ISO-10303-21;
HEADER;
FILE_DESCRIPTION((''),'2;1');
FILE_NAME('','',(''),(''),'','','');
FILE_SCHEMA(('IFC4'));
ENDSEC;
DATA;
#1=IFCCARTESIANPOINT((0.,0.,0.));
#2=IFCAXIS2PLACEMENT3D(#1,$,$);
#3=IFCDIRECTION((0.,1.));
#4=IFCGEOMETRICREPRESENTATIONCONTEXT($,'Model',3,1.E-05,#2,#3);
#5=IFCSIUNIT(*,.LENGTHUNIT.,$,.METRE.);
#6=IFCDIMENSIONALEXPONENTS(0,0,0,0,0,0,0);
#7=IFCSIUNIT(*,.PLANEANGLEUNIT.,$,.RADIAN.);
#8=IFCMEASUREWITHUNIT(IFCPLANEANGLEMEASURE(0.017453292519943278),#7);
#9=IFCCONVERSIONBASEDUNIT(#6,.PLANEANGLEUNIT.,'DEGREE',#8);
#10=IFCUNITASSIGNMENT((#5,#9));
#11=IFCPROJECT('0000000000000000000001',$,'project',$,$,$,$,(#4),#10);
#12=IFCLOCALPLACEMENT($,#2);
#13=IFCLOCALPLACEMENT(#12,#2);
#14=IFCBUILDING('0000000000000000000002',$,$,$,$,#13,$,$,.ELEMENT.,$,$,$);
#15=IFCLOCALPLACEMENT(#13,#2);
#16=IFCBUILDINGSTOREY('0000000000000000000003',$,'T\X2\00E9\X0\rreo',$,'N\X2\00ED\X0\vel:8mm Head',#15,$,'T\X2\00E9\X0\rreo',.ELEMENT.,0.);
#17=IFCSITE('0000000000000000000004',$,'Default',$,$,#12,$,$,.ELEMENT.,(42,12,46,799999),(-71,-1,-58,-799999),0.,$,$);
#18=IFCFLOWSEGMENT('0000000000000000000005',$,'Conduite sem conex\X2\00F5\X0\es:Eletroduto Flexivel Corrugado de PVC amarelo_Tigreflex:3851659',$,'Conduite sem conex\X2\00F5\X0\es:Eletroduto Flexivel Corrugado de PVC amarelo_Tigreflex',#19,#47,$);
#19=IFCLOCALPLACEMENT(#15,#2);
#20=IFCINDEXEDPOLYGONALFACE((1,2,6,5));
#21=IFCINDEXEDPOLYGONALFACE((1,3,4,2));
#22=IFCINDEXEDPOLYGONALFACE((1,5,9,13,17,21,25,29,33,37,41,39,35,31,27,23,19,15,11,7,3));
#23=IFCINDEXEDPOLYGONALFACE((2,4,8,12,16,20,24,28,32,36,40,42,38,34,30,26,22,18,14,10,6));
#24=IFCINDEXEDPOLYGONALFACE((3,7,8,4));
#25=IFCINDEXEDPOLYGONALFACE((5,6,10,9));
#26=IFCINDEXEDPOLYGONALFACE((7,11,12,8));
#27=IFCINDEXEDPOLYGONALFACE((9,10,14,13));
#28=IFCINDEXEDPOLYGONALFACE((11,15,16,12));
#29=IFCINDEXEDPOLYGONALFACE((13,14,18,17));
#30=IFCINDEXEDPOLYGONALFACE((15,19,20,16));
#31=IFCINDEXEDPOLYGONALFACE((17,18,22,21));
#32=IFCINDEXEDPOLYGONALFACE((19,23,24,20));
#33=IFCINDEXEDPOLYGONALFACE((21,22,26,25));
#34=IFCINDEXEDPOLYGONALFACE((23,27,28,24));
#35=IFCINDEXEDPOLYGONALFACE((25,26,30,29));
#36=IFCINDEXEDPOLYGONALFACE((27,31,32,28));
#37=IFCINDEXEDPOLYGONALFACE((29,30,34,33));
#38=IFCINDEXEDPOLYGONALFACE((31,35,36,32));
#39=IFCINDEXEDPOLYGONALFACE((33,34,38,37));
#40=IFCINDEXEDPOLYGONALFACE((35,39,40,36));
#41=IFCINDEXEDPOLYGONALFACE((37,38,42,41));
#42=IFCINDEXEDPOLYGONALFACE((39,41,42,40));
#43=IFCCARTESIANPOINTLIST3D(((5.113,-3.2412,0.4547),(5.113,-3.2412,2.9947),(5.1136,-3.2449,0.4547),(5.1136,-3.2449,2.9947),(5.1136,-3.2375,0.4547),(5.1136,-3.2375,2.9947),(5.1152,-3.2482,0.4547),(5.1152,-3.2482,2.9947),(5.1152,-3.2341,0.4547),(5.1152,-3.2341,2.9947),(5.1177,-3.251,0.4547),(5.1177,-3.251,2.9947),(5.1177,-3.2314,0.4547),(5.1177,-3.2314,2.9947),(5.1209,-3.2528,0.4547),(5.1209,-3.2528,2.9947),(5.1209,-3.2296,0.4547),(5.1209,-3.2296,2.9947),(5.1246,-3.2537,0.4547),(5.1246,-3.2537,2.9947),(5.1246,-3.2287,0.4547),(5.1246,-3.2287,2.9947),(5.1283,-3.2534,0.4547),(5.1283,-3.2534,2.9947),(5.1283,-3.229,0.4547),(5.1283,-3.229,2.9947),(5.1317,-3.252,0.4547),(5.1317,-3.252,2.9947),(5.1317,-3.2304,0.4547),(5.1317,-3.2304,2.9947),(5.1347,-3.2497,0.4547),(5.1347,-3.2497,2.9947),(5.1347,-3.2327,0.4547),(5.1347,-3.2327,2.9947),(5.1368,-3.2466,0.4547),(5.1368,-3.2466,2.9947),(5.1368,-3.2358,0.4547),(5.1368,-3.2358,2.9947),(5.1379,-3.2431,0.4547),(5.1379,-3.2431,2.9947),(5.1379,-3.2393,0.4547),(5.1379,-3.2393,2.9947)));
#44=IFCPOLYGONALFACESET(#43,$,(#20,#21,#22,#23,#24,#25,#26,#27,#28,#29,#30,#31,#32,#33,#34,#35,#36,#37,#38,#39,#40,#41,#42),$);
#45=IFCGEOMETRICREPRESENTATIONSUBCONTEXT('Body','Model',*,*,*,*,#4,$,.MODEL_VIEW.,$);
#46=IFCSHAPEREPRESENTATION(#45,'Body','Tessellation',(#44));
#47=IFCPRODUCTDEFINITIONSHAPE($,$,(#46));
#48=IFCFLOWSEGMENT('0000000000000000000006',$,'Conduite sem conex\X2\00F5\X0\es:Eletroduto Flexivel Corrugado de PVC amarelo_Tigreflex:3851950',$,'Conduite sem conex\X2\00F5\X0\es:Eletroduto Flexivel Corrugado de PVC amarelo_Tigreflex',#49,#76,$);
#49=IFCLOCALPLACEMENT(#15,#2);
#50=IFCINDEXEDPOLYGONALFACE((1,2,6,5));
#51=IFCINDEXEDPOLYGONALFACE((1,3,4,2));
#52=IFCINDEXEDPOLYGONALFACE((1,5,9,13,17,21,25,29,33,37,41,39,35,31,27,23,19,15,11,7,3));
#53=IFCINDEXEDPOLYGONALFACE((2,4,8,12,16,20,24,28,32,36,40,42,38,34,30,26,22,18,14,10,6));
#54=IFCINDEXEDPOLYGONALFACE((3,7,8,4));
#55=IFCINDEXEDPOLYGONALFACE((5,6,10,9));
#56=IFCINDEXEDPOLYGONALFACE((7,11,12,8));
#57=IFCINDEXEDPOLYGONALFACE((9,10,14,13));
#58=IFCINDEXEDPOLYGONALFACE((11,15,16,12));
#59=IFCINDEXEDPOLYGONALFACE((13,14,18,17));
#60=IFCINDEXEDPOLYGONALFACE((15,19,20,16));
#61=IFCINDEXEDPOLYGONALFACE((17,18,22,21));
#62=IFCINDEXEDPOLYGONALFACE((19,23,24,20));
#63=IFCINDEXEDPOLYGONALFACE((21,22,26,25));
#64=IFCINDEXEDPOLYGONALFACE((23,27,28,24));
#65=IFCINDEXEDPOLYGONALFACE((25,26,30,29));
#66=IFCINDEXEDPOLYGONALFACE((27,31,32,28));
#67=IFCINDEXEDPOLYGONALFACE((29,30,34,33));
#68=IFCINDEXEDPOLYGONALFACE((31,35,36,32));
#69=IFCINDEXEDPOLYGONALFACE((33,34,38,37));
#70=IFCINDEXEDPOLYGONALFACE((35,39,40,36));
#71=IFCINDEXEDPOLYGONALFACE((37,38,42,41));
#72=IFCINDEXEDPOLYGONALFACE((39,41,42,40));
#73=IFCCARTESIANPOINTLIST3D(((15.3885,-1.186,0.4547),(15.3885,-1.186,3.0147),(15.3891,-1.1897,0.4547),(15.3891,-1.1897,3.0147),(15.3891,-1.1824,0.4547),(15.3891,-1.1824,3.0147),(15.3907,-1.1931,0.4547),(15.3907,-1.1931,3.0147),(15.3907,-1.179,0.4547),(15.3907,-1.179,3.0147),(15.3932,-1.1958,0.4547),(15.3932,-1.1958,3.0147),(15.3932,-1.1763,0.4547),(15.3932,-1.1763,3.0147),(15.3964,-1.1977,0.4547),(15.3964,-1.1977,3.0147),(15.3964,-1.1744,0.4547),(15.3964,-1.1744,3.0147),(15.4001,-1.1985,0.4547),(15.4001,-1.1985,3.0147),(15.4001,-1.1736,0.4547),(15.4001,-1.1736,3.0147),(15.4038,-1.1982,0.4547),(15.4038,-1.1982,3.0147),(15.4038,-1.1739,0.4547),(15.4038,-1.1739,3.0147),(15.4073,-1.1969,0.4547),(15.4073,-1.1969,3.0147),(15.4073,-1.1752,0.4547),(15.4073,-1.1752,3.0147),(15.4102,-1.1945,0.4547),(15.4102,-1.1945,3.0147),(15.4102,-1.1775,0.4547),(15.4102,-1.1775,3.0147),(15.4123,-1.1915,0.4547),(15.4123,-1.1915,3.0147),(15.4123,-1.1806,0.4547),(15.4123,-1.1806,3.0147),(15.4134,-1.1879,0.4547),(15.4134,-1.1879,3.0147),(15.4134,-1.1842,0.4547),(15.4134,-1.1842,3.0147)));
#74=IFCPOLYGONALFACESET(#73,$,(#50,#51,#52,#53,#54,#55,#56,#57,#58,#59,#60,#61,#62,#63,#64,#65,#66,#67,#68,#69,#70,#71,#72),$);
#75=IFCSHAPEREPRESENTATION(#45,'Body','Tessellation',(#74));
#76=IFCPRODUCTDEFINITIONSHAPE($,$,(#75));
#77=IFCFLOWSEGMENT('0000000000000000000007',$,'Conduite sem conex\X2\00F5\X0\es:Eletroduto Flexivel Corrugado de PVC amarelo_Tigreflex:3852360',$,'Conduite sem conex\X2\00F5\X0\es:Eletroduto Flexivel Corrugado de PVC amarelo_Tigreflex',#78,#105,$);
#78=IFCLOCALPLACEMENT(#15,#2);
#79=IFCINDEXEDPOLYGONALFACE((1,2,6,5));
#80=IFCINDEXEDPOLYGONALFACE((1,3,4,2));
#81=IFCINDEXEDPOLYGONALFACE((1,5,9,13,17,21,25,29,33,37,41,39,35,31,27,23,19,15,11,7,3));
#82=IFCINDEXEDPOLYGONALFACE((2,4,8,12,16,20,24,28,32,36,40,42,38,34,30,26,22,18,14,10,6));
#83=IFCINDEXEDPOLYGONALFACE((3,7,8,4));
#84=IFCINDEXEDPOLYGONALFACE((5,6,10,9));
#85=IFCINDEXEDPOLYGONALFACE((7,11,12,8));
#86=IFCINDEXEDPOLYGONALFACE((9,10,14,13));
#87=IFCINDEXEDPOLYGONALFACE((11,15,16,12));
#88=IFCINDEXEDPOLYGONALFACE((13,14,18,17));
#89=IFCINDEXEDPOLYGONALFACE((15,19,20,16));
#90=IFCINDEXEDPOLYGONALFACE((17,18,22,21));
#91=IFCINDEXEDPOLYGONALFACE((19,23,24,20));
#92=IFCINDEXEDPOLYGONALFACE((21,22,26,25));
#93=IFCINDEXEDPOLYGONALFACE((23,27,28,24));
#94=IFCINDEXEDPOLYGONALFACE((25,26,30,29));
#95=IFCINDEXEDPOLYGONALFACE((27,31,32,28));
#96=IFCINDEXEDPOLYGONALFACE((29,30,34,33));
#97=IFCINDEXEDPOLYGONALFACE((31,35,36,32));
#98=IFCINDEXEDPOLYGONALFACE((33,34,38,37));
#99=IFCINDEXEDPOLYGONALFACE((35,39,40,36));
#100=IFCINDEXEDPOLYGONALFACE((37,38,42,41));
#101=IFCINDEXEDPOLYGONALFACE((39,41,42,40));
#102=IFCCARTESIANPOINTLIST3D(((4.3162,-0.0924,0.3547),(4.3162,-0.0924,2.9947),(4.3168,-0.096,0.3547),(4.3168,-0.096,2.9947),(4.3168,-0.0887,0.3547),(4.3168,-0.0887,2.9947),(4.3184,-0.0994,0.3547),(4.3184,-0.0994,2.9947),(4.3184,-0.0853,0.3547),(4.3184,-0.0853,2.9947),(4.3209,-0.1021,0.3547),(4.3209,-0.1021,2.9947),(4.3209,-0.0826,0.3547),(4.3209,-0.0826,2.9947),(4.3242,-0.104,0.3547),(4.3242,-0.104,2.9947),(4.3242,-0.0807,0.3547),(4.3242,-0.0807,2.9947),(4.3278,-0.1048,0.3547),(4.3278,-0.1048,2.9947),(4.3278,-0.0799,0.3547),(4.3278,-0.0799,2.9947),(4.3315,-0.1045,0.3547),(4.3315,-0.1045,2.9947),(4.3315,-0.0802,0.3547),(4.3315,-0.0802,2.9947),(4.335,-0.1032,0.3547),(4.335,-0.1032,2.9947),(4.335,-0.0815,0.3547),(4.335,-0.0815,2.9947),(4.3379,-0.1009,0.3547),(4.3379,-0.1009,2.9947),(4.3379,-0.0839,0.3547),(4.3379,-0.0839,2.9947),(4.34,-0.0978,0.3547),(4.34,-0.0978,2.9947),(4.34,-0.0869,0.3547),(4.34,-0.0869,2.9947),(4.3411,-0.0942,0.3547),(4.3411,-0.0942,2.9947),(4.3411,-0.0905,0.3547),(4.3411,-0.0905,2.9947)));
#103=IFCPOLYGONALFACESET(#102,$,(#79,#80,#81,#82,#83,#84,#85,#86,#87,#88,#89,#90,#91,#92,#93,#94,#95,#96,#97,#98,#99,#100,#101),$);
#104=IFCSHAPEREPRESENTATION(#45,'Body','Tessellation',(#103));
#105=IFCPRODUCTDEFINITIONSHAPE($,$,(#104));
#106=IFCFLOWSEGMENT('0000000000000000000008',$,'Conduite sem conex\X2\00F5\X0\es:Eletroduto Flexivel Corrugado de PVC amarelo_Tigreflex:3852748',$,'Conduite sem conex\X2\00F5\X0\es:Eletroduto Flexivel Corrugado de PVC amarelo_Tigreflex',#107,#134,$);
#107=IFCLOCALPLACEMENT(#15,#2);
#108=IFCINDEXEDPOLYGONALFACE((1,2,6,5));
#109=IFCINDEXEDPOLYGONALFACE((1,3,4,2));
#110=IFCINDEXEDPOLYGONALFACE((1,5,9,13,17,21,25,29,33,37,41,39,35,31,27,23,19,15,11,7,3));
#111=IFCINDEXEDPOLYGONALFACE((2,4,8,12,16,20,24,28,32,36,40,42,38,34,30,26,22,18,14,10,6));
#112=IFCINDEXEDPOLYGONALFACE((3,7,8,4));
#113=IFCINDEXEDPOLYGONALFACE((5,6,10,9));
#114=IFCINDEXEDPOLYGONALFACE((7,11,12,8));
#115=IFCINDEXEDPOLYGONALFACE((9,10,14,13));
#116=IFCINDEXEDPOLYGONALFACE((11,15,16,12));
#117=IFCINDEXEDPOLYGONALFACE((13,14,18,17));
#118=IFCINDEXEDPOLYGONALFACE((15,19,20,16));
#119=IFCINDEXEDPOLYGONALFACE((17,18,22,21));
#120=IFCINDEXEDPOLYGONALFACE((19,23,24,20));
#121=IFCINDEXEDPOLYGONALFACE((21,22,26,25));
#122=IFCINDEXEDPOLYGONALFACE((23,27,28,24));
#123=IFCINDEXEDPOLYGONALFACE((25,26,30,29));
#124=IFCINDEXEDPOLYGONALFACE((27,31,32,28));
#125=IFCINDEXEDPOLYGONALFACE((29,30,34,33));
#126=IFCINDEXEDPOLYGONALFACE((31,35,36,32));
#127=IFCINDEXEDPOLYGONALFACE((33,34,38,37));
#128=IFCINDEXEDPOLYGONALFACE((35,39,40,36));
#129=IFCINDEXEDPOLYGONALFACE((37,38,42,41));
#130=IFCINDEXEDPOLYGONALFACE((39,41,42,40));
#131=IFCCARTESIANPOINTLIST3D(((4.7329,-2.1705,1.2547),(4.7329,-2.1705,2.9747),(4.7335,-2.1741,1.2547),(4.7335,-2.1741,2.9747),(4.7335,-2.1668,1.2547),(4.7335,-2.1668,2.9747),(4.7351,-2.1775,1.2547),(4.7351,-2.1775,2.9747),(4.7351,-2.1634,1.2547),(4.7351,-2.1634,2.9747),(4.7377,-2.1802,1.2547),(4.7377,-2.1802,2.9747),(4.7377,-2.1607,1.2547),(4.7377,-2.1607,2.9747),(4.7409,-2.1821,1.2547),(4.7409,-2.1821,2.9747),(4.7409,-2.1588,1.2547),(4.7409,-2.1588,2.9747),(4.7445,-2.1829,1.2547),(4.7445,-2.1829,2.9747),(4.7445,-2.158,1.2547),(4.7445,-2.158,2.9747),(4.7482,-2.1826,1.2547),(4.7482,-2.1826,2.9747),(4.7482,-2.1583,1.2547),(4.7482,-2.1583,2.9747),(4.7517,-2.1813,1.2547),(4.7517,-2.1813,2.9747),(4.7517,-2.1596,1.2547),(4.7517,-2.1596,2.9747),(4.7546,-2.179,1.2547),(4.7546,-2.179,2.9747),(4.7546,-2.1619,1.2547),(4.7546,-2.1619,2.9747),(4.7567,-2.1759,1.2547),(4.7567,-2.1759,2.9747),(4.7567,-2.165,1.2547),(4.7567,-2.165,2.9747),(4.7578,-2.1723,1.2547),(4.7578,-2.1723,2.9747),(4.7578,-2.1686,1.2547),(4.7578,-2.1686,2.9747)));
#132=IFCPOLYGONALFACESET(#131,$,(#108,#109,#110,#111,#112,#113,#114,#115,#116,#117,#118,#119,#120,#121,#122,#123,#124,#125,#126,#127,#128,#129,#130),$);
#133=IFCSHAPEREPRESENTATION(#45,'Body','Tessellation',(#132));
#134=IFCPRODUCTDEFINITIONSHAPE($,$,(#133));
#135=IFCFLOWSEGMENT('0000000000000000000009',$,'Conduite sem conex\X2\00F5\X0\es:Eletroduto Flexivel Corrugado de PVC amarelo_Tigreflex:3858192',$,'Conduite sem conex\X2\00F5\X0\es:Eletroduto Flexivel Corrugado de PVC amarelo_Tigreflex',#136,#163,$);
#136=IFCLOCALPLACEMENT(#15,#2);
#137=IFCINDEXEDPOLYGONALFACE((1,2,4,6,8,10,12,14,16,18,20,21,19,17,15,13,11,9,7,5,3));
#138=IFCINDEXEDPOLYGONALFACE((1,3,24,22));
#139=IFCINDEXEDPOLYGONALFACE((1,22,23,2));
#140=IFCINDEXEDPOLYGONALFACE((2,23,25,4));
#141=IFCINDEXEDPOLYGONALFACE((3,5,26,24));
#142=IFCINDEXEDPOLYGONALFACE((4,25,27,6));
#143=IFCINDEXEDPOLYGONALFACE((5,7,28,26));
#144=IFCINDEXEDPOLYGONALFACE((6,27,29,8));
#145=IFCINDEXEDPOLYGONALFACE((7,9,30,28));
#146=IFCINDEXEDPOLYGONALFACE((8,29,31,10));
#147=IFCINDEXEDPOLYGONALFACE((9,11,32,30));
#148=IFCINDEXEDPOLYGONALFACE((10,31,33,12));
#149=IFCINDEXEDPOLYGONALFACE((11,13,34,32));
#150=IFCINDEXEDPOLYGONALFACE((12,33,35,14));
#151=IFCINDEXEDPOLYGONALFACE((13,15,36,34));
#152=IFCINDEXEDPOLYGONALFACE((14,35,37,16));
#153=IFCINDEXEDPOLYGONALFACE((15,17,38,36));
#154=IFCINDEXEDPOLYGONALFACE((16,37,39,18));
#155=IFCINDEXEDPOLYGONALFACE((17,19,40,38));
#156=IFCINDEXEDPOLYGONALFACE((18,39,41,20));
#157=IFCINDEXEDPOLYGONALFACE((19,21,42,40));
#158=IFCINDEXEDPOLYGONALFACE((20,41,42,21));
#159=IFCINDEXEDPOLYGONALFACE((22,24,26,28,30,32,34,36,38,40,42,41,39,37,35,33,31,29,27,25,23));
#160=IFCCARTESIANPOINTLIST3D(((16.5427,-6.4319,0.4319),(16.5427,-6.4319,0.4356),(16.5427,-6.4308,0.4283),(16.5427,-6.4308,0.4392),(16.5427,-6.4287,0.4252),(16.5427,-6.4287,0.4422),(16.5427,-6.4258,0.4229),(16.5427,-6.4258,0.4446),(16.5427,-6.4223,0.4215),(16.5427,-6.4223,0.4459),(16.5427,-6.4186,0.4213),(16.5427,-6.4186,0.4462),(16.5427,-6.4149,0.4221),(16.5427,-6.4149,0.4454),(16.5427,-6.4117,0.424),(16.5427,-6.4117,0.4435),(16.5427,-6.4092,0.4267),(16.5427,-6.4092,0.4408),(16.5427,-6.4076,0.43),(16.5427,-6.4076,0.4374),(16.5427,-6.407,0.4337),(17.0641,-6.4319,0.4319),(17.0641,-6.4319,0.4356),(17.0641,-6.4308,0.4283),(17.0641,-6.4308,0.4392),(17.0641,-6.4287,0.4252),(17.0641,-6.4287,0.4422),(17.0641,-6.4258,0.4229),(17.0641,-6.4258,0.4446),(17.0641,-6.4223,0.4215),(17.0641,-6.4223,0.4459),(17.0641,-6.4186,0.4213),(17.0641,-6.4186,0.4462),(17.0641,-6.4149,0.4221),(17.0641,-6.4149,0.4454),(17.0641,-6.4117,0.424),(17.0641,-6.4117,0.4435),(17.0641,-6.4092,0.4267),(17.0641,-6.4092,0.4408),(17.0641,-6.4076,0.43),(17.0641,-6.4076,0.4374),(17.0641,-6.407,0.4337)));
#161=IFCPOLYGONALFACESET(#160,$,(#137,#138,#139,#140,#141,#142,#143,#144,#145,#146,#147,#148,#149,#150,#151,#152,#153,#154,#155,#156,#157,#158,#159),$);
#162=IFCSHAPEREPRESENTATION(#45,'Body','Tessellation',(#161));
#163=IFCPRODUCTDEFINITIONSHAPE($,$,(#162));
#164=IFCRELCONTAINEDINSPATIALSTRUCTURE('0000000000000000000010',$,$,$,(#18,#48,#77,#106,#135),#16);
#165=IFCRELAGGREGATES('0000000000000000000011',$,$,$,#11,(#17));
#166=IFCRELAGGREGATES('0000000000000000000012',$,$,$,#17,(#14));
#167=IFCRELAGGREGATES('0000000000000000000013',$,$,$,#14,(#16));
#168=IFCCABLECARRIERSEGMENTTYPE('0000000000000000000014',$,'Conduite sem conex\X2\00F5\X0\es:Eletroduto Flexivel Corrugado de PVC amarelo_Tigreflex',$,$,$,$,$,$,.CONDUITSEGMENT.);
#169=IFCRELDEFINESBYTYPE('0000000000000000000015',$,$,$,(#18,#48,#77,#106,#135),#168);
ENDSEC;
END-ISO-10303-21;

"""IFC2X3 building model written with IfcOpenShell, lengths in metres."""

from ifc_helpers import new_model, entity, si_unit, converted_unit, direction, frame, frame_2d, origin, origin_2d_with_axis, place, context, subcontext, project, spatial, circle, extrude, type_object, element, save


model = new_model("IFC2X3")

# Units and contexts
model_context = context("Model", 3, precision=1e-05, world=origin(), true_north=direction((0.0, 1.0)))
body_context = subcontext(model_context, "Body", "Model", "MODEL_VIEW")
ifc_project = project(units=[si_unit("LENGTHUNIT", "METRE"), converted_unit("PLANEANGLEUNIT", "DEGREE", entity("IfcPlaneAngleMeasure", 0.017453292519943278), si_unit("PLANEANGLEUNIT", "RADIAN"), dimensions=[0, 0, 0, 0, 0, 0, 0])], contexts=[model_context])

# Site, building, storey
site_placement = place(None, origin())
site = spatial("IfcSite", under=ifc_project, at=site_placement, Name="Default", CompositionType="ELEMENT", RefLatitude=(42, 12, 46, 799999), RefLongitude=(-71, -1, -58, -799999), RefElevation=0.0)
building_placement = place(site_placement, origin())
building = spatial("IfcBuilding", under=site, at=building_placement, CompositionType="ELEMENT")
storey_placement = place(building_placement, origin())
storey = spatial("IfcBuildingStorey", under=building, at=storey_placement, Name="Térreo", ObjectType="Nível:8mm Head", LongName="Térreo", CompositionType="ELEMENT", Elevation=0.0)

# Flow segments
cable_carrier_segment_type = type_object("IfcCableCarrierSegmentType", Name="Conduite sem conexões:Eletroduto Flexivel Corrugado de PVC amarelo_Tigreflex", PredefinedType="CONDUITSEGMENT")
flow_segment_1_placement = place(storey_placement, origin())
element("IfcFlowSegment", 1, at=flow_segment_1_placement, inside=storey, type_object=cable_carrier_segment_type, Name="Conduite sem conexões:Eletroduto Flexivel Corrugado de PVC amarelo_Tigreflex:3851659", ObjectType="Conduite sem conexões:Eletroduto Flexivel Corrugado de PVC amarelo_Tigreflex", context=body_context, shape_type="SweptSolid", body=[
    extrude(circle(Radius=0.0125, at=origin_2d_with_axis()), frame((5.1255, -3.2412, 0.4547), z_axis=(0.0, 0.0, 1.0), x_axis=(-1.0, 0.0, 0.0)), (0.0, 0.0, 1.0), 2.54),
])
flow_segment_2_placement = place(storey_placement, origin())
element("IfcFlowSegment", 2, at=flow_segment_2_placement, inside=storey, type_object=cable_carrier_segment_type, Name="Conduite sem conexões:Eletroduto Flexivel Corrugado de PVC amarelo_Tigreflex:3851950", ObjectType="Conduite sem conexões:Eletroduto Flexivel Corrugado de PVC amarelo_Tigreflex", context=body_context, shape_type="SweptSolid", body=[
    extrude(circle(Radius=0.0125, at=origin_2d_with_axis()), frame((15.401, -1.186, 0.4547), z_axis=(0.0, 0.0, 1.0), x_axis=(-1.0, 0.0, 0.0)), (0.0, 0.0, 1.0), 2.56),
])
flow_segment_3_placement = place(storey_placement, origin())
element("IfcFlowSegment", 3, at=flow_segment_3_placement, inside=storey, type_object=cable_carrier_segment_type, Name="Conduite sem conexões:Eletroduto Flexivel Corrugado de PVC amarelo_Tigreflex:3852360", ObjectType="Conduite sem conexões:Eletroduto Flexivel Corrugado de PVC amarelo_Tigreflex", context=body_context, shape_type="SweptSolid", body=[
    extrude(circle(Radius=0.0125, at=frame_2d((0.0, 0.0), x_axis=(1.0, 0.0))), frame((4.3287, -0.0924, 0.3547), z_axis=(0.0, 0.0, 1.0), x_axis=(-1.0, 0.0, 0.0)), (0.0, 0.0, 1.0), 2.64),
])
flow_segment_4_placement = place(storey_placement, origin())
element("IfcFlowSegment", 4, at=flow_segment_4_placement, inside=storey, type_object=cable_carrier_segment_type, Name="Conduite sem conexões:Eletroduto Flexivel Corrugado de PVC amarelo_Tigreflex:3852748", ObjectType="Conduite sem conexões:Eletroduto Flexivel Corrugado de PVC amarelo_Tigreflex", context=body_context, shape_type="SweptSolid", body=[
    extrude(circle(Radius=0.0125, at=frame_2d((0.0, 0.0), x_axis=(1.0, 0.0))), frame((4.7454, -2.1705, 1.2547), z_axis=(0.0, 0.0, 1.0), x_axis=(-1.0, 0.0, 0.0)), (0.0, 0.0, 1.0), 1.72),
])
flow_segment_5_placement = place(storey_placement, origin())
element("IfcFlowSegment", 5, at=flow_segment_5_placement, inside=storey, type_object=cable_carrier_segment_type, Name="Conduite sem conexões:Eletroduto Flexivel Corrugado de PVC amarelo_Tigreflex:3858192", ObjectType="Conduite sem conexões:Eletroduto Flexivel Corrugado de PVC amarelo_Tigreflex", context=body_context, shape_type="SweptSolid", body=[
    extrude(circle(Radius=0.0125, at=frame_2d((0.0, 0.0), x_axis=(1.0, 0.0))), frame((16.5427, -6.4195, 0.4337), z_axis=(1.0, 0.0, 0.0), x_axis=(0.0, 1.0, 0.0)), (0.0, 0.0, 1.0), 0.5214),
])

save(model, "model.ifc")
